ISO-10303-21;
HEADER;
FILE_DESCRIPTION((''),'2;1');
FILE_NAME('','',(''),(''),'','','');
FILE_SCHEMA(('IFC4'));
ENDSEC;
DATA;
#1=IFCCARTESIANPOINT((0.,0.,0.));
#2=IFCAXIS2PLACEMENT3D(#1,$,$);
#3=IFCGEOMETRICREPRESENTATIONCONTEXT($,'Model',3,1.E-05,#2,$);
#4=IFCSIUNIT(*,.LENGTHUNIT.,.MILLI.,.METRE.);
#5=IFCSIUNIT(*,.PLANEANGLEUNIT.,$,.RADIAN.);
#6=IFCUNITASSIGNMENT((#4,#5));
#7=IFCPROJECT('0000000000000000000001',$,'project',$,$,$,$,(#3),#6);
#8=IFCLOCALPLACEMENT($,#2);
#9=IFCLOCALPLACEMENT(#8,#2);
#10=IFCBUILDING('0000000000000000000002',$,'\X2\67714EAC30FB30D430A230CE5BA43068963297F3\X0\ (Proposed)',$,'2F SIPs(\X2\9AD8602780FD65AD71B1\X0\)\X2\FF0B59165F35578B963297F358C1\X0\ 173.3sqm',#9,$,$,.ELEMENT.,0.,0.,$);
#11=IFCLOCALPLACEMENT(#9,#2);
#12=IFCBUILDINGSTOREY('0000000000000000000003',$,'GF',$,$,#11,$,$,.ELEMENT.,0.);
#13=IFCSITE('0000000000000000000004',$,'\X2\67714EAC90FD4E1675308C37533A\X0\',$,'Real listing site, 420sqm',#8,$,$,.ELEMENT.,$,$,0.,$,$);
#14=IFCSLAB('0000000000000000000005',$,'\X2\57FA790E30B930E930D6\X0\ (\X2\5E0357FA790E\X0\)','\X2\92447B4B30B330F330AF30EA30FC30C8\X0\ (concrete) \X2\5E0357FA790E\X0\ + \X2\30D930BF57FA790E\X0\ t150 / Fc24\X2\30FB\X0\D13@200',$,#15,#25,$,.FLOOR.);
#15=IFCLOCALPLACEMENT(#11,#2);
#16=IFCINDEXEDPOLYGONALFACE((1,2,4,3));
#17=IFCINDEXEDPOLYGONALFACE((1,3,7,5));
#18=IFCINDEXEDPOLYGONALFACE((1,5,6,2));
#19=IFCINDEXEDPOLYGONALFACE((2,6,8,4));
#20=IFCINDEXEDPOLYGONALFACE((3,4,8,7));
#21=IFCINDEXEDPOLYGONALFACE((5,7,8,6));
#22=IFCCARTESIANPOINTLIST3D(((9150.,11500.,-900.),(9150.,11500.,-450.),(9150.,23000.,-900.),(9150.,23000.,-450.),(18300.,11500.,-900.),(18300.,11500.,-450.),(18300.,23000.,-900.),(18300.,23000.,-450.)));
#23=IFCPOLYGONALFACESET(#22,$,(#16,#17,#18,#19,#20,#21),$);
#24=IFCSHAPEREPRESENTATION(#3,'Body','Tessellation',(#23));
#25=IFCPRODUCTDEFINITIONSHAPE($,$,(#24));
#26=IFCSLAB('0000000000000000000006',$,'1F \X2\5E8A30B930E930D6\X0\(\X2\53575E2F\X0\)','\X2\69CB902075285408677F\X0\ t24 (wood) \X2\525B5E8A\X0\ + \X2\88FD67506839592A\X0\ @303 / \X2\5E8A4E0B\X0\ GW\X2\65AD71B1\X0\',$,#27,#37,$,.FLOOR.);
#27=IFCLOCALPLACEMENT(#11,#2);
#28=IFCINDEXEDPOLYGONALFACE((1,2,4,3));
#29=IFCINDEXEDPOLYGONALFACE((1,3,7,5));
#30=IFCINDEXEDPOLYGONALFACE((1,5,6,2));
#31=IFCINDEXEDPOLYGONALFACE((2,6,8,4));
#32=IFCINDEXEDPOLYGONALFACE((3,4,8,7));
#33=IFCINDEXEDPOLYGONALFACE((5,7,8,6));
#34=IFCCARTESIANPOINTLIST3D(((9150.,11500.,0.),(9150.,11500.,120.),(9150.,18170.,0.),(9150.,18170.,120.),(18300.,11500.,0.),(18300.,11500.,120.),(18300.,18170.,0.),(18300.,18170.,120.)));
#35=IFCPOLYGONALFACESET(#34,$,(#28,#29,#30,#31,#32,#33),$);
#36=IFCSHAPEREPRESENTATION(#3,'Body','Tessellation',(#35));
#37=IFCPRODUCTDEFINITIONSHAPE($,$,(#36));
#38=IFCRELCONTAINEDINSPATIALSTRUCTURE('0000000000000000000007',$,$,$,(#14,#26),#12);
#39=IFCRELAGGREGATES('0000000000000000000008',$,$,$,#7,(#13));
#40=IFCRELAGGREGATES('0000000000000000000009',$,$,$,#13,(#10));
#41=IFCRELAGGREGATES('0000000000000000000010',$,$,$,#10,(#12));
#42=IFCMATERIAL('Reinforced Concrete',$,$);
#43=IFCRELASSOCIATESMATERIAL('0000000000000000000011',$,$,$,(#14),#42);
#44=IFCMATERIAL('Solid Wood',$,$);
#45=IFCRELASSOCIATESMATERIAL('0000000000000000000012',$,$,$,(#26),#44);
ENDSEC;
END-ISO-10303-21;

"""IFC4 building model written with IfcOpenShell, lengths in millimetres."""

from ifc_helpers import new_model, si_unit, frame, frame_2d, origin, place, context, project, spatial, rectangle, extrude, material, element, save


model = new_model("IFC4")

# Units and contexts
model_context = context("Model", 3, precision=1e-05, world=origin())
ifc_project = project(units=[si_unit("LENGTHUNIT", "METRE", prefix="MILLI"), si_unit("PLANEANGLEUNIT", "RADIAN")], contexts=[model_context])

# Site, building, storey
site_placement = place(None, origin())
site = spatial("IfcSite", under=ifc_project, at=site_placement, Name="東京都世田谷区", ObjectType="Real listing site, 420sqm", CompositionType="ELEMENT", RefElevation=0.0)
building_placement = place(site_placement, origin())
building = spatial("IfcBuilding", under=site, at=building_placement, Name="東京・ピアノ室と防音 (Proposed)", ObjectType="2F SIPs(高性能断熱)＋外張型防音壁 173.3sqm", CompositionType="ELEMENT", ElevationOfRefHeight=0.0, ElevationOfTerrain=0.0)
storey_placement = place(building_placement, origin())
storey = spatial("IfcBuildingStorey", under=building, at=storey_placement, Name="GF", CompositionType="ELEMENT", Elevation=0.0)

# Shared definitions
ifc_material_1 = material(Name="Solid Wood")

# Slabs
ifc_material_2 = material(Name="Reinforced Concrete")
slab_1_placement = place(storey_placement, frame((4575.0, 5750.0, -450.0)))
element("IfcSlab", 1, at=slab_1_placement, inside=storey, material=ifc_material_2, Name="基礎スラブ (布基礎)", Description="鉄筋コンクリート (concrete) 布基礎 + ベタ基礎 t150 / Fc24・D13@200", PredefinedType="FLOOR", context=model_context, shape_type="SweptSolid", body=[
    extrude(rectangle(XDim=9150.0, YDim=11500.0, at=frame_2d((4575.0, 5750.0))), frame((4575.0, 5750.0, -450.0)), (0.0, 0.0, 1.0), 450.0),
])
slab_2_placement = place(storey_placement, frame((4575.0, 5750.0, 0.0)))
element("IfcSlab", 2, at=slab_2_placement, inside=storey, material=ifc_material_1, Name="1F 床スラブ(南帯)", Description="構造用合板 t24 (wood) 剛床 + 製材根太 @303 / 床下 GW断熱", PredefinedType="FLOOR", context=model_context, shape_type="SweptSolid", body=[
    extrude(rectangle(XDim=9150.0, YDim=6670.0, at=frame_2d((4575.0, 3335.0))), frame((4575.0, 5750.0, 0.0)), (0.0, 0.0, 1.0), 120.0),
])

save(model, "model.ifc")
